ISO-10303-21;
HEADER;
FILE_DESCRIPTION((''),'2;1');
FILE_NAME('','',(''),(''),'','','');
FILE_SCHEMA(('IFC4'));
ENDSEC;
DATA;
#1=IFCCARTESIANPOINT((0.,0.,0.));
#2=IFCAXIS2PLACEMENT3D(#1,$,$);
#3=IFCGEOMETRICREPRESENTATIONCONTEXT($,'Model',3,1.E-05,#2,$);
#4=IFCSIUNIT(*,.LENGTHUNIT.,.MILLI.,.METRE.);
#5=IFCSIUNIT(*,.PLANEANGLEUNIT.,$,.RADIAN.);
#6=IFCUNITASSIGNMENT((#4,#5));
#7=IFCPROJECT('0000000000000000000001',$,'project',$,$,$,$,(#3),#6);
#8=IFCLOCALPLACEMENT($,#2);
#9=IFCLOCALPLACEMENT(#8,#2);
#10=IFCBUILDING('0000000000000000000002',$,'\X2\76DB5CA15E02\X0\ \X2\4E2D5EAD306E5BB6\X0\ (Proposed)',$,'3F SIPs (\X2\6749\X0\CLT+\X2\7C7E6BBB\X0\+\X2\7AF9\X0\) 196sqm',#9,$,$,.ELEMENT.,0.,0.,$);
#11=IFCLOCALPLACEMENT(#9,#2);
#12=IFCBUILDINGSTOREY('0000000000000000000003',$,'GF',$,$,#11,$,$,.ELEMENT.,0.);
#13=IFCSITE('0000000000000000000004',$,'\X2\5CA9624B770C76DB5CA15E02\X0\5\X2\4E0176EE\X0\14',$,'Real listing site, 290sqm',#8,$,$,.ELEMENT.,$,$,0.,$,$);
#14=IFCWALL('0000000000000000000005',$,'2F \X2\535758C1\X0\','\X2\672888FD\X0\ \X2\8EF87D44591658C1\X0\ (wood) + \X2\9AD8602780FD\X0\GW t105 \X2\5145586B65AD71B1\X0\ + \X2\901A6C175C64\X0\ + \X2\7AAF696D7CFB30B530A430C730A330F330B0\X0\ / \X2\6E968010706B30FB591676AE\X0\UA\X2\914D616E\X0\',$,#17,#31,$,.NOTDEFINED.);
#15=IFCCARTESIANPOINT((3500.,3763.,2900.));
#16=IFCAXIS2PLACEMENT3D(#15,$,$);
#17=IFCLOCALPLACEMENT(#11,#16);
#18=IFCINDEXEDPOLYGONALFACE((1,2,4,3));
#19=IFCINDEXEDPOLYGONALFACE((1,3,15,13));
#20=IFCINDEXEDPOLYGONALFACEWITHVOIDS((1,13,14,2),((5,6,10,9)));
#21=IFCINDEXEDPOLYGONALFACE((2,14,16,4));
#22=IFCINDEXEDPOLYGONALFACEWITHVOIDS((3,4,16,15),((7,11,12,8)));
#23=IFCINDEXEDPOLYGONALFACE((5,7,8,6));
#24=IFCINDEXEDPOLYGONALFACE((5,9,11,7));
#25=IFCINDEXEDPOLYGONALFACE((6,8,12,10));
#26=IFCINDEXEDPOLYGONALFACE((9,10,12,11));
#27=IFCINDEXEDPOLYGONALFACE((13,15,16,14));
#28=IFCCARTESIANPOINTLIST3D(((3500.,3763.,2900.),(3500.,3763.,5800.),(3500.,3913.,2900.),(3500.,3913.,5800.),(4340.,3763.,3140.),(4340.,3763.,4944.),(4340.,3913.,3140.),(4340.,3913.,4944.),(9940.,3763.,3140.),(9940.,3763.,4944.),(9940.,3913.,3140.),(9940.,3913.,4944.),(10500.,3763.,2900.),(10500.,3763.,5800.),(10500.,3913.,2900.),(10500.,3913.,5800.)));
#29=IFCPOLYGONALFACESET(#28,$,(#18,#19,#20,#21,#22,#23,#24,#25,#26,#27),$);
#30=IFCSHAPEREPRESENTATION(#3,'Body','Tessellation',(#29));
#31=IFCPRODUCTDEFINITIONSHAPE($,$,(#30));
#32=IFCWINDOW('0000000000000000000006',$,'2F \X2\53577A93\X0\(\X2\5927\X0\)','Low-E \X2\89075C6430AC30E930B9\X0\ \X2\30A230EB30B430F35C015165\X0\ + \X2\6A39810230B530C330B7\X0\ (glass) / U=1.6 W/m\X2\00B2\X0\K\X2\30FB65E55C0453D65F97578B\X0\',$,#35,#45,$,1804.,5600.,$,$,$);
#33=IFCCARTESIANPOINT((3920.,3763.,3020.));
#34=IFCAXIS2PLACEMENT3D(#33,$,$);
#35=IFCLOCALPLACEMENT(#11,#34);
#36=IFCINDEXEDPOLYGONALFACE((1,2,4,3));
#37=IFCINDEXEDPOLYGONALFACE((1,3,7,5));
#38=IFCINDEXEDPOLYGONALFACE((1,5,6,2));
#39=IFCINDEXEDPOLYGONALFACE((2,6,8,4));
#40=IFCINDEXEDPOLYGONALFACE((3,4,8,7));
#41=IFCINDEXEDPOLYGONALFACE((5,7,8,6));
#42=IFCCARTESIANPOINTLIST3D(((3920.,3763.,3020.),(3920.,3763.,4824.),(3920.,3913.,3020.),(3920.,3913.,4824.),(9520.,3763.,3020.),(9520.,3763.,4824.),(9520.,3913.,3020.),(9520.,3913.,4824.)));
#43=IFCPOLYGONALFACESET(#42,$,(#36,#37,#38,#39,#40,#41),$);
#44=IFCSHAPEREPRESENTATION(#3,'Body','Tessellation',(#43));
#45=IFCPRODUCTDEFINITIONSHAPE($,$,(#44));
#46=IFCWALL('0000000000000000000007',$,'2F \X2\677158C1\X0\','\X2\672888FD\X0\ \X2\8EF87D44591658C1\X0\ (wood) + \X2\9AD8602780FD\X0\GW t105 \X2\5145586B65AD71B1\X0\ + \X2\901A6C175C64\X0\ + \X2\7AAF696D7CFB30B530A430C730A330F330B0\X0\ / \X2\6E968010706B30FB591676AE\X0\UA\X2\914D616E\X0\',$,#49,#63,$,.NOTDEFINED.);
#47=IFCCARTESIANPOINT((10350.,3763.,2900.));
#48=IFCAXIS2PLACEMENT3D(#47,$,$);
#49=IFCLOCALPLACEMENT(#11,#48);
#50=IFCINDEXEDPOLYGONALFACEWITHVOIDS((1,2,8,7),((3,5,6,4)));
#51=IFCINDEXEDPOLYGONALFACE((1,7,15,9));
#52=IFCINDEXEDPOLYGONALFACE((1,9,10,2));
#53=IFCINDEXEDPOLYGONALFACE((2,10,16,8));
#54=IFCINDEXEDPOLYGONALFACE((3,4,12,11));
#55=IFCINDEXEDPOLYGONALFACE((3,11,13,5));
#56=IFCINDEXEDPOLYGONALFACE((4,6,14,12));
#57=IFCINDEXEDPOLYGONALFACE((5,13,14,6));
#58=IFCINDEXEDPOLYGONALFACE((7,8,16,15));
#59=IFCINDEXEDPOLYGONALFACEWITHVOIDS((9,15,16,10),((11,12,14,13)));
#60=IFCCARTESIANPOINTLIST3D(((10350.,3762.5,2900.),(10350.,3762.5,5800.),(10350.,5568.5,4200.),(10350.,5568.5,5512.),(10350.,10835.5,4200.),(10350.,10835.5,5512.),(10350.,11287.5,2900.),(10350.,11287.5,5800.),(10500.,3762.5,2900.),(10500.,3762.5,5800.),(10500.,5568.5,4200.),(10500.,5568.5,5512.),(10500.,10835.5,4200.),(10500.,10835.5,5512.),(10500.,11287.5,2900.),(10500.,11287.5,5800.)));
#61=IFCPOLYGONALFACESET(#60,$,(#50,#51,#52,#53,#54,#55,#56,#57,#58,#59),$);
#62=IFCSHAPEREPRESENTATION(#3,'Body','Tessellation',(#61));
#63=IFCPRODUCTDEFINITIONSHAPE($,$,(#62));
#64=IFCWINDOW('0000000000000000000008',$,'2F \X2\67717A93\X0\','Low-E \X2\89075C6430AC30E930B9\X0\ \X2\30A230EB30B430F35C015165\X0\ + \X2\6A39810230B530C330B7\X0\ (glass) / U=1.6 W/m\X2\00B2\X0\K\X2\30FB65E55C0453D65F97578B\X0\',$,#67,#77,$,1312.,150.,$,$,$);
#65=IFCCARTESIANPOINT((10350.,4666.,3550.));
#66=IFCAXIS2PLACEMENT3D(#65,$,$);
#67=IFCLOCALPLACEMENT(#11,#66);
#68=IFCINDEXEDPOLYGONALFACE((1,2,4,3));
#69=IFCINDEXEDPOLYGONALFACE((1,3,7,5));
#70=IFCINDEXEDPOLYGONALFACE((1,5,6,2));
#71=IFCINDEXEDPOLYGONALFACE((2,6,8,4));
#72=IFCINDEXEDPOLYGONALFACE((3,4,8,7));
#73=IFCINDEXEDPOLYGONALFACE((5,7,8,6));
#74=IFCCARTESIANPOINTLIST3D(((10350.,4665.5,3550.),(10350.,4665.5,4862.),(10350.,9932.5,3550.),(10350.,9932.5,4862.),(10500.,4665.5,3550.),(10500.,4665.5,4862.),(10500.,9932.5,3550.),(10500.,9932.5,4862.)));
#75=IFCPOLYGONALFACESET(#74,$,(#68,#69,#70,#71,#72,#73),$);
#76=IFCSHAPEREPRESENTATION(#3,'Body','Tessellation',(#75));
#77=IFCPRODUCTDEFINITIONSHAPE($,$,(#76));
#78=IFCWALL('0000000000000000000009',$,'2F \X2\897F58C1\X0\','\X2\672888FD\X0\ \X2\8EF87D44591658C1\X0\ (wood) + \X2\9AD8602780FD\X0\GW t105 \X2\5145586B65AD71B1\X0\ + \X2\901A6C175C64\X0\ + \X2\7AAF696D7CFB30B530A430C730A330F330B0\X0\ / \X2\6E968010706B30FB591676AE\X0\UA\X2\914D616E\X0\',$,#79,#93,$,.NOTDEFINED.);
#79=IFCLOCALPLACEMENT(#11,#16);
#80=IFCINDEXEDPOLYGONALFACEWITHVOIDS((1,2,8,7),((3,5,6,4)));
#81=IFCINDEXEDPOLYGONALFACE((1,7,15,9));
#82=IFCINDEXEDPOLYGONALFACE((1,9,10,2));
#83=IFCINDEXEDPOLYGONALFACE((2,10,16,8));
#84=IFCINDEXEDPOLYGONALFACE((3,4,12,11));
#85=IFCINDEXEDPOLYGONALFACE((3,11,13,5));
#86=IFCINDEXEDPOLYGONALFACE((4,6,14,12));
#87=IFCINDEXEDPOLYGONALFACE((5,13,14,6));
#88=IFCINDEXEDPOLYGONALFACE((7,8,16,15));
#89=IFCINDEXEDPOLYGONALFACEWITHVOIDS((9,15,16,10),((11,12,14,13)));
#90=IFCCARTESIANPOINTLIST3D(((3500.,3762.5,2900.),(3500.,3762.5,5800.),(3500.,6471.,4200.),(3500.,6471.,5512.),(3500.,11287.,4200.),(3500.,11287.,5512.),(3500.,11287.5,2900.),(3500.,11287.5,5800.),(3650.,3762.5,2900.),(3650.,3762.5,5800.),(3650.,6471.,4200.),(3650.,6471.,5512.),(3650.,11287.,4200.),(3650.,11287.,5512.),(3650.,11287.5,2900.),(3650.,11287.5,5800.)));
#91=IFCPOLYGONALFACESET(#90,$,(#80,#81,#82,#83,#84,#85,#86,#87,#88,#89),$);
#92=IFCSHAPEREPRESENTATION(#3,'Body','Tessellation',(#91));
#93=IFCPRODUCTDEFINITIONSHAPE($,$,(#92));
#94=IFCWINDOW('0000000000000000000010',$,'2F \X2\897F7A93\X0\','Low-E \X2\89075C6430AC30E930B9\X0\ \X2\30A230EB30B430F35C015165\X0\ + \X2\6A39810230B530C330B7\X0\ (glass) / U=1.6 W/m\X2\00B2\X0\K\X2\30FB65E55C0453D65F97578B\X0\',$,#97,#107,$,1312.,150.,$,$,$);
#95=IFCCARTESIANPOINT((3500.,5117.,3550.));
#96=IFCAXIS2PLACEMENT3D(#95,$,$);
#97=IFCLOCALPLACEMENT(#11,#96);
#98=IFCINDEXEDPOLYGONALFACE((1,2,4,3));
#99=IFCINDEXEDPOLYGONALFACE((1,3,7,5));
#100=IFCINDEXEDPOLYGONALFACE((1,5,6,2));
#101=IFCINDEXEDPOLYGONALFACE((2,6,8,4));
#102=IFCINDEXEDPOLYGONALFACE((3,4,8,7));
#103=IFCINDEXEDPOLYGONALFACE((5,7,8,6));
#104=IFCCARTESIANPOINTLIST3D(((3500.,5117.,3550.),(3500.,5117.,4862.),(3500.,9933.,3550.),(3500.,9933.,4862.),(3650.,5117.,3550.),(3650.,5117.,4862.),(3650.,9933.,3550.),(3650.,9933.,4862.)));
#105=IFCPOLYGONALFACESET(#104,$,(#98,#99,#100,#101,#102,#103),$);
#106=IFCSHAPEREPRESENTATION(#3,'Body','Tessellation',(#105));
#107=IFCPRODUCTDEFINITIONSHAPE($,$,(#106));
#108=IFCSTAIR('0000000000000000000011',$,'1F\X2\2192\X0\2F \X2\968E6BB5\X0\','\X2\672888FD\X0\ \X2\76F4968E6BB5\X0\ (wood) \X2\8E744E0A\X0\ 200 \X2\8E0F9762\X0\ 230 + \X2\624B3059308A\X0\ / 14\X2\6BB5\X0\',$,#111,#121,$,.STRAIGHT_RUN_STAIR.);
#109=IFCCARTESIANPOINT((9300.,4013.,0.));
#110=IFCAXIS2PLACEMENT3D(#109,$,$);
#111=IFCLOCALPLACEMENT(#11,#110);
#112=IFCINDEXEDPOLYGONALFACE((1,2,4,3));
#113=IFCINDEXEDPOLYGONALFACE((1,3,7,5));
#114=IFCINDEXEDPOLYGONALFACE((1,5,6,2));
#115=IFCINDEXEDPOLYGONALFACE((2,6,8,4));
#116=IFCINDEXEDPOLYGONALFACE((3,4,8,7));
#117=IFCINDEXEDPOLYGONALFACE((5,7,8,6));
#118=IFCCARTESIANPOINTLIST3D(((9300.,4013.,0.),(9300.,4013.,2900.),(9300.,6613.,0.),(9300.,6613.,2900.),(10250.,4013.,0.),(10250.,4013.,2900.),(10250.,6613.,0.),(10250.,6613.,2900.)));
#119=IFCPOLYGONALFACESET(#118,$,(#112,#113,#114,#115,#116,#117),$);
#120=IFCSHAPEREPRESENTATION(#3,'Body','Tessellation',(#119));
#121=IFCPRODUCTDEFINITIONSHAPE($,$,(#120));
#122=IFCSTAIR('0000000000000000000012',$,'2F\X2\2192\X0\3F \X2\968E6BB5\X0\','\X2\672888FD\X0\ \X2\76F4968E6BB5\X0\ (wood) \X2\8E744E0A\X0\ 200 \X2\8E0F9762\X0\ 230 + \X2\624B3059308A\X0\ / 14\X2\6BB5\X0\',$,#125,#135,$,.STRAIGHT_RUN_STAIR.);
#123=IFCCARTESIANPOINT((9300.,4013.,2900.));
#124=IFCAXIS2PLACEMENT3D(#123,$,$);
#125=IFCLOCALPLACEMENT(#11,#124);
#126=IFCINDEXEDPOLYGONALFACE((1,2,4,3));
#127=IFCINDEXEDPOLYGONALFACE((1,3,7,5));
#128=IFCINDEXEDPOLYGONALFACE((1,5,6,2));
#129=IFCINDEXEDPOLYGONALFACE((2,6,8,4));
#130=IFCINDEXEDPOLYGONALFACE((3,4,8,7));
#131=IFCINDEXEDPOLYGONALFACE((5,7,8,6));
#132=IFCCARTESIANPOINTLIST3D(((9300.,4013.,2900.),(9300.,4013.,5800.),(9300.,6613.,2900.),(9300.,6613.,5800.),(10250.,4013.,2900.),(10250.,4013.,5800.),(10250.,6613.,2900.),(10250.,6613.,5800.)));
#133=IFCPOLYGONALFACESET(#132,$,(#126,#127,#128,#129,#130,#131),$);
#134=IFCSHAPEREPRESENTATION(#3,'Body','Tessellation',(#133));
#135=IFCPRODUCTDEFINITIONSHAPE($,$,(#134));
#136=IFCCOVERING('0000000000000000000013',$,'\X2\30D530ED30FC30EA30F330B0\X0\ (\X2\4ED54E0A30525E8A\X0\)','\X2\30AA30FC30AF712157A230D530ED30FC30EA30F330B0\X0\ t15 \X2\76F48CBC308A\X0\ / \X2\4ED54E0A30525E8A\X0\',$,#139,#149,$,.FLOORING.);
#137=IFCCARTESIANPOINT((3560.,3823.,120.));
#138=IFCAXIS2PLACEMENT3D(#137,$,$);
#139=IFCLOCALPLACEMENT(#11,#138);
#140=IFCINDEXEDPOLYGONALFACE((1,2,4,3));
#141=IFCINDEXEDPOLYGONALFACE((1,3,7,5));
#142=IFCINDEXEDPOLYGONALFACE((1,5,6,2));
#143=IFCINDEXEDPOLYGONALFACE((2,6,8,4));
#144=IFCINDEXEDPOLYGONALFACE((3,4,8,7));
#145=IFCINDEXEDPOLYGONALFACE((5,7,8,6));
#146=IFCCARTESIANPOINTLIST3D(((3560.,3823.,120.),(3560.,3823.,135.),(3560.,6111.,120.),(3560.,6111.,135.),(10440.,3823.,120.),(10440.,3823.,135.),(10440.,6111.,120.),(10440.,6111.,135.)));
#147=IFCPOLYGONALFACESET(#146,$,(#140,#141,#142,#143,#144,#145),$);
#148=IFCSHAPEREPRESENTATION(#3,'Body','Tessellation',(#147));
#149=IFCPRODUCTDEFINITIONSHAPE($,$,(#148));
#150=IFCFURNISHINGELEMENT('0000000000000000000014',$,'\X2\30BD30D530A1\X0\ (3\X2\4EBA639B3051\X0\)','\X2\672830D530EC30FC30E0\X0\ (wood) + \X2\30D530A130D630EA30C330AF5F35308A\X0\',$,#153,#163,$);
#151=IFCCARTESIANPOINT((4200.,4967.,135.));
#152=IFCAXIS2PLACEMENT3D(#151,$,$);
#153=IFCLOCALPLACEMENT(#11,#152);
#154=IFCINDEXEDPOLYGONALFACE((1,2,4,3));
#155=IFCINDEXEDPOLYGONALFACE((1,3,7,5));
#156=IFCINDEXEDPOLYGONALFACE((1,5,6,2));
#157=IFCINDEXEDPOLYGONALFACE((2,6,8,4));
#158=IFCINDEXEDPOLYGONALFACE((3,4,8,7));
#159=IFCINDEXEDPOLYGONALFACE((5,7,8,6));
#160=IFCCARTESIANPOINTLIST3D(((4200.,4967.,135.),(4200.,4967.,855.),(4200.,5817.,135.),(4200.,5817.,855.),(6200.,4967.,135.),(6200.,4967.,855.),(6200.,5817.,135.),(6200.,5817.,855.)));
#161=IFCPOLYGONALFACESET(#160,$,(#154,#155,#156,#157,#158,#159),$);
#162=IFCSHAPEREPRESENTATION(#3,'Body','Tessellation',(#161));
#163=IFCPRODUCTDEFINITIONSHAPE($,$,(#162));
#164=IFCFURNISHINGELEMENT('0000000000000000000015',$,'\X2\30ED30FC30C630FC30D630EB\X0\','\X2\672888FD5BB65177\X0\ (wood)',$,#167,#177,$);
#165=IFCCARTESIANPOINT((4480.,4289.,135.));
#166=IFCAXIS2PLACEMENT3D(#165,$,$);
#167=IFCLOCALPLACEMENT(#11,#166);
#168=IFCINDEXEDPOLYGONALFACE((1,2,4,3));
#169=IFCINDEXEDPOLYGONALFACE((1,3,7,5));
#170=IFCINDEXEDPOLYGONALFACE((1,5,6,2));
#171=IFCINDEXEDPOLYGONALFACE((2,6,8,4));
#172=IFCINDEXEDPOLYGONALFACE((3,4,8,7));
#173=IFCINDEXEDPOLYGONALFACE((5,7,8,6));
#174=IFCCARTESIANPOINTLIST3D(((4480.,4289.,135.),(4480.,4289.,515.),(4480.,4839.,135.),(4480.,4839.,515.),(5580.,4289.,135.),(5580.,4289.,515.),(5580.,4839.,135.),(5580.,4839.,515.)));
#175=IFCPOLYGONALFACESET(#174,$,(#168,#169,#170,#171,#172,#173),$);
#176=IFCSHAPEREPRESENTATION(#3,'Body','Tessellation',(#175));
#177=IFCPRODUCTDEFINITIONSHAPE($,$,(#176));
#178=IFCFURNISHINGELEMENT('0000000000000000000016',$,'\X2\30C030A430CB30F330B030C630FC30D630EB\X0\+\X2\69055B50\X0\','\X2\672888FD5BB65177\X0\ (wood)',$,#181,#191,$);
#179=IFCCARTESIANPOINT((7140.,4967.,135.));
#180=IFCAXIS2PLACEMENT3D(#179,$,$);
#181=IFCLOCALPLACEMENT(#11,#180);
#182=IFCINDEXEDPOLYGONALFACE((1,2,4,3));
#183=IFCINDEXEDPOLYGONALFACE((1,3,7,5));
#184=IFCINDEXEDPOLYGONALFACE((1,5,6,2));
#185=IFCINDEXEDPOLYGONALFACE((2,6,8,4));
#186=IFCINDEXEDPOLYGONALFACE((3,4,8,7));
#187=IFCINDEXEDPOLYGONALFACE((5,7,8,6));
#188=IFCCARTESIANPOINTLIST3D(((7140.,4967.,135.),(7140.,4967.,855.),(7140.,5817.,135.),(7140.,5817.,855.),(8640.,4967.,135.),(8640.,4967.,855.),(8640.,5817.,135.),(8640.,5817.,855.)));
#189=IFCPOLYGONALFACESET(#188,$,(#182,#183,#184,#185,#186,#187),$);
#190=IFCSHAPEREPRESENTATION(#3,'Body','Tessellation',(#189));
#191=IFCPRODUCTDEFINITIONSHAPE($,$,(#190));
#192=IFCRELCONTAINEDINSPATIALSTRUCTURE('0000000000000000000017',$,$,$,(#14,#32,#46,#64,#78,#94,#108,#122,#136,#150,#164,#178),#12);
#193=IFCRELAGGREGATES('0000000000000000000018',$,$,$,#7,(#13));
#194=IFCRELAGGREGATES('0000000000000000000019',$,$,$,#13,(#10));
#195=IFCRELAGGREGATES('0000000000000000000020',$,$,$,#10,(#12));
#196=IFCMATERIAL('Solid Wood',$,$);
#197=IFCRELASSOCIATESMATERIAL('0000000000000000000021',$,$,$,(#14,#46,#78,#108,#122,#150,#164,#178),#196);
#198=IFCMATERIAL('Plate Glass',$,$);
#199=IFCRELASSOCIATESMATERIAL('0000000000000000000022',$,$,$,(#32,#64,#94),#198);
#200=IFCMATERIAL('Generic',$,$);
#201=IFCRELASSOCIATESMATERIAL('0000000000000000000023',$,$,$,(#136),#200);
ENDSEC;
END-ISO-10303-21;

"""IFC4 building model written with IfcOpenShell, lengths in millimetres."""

from ifc_helpers import new_model, si_unit, frame, frame_2d, origin, place, context, project, spatial, rectangle, extrude, material, element, fill, save


model = new_model("IFC4")

# Units and contexts
model_context = context("Model", 3, precision=1e-05, world=origin())
ifc_project = project(units=[si_unit("LENGTHUNIT", "METRE", prefix="MILLI"), si_unit("PLANEANGLEUNIT", "RADIAN")], contexts=[model_context])

# Site, building, storey
site_placement = place(None, origin())
site = spatial("IfcSite", under=ifc_project, at=site_placement, Name="岩手県盛岡市5丁目14", ObjectType="Real listing site, 290sqm", CompositionType="ELEMENT", RefElevation=0.0)
building_placement = place(site_placement, origin())
building = spatial("IfcBuilding", under=site, at=building_placement, Name="盛岡市 中庭の家 (Proposed)", ObjectType="3F SIPs (杉CLT+籾殻+竹) 196sqm", CompositionType="ELEMENT", ElevationOfRefHeight=0.0, ElevationOfTerrain=0.0)
storey_placement = place(building_placement, origin())
storey = spatial("IfcBuildingStorey", under=building, at=storey_placement, Name="GF", CompositionType="ELEMENT", Elevation=0.0)

# Shared definitions
ifc_material_1 = material(Name="Solid Wood")

# Shared definitions
ifc_material_2 = material(Name="Plate Glass")

# Walls, openings, windows
wall_1_placement = place(storey_placement, frame((3500.0, 3763.0, 2900.0)))
wall_1 = element("IfcWall", 1, at=wall_1_placement, inside=storey, material=ifc_material_1, Name="2F 南壁", Description="木製 軸組外壁 (wood) + 高性能GW t105 充填断熱 + 通気層 + 窯業系サイディング / 準耐火・外皮UA配慮", PredefinedType="NOTDEFINED", context=model_context, shape_type="SweptSolid", body=[
    extrude(rectangle(XDim=7000.0, YDim=150.0, at=frame_2d((3500.0, 75.0))), frame((3500.0, 3763.0, 2900.0)), (0.0, 0.0, 1.0), 2900.0),
])
opening_1_placement = place(storey_placement, frame((3920.0, 3763.0, 3020.0)))
opening_1 = element("IfcOpeningElement", 2, at=opening_1_placement, cuts=wall_1, PredefinedType="NOTDEFINED", context=model_context, shape_type="SweptSolid", body=[
    extrude(rectangle(XDim=5600.0, YDim=150.0, at=frame_2d((2800.0, 75.0))), frame((3920.0, 3763.0, 3020.0)), (0.0, 0.0, 1.0), 1804.0),
])
window_1_placement = place(storey_placement, frame((3920.0, 3763.0, 3020.0)))
window_1 = element("IfcWindow", 3, at=window_1_placement, inside=storey, material=ifc_material_2, Name="2F 南窓(大)", Description="Low-E 複層ガラス アルゴン封入 + 樹脂サッシ (glass) / U=1.6 W/m²K・日射取得型", OverallHeight=1804.0, OverallWidth=5600.0, context=model_context, shape_type="SweptSolid", body=[
    extrude(rectangle(XDim=5600.0, YDim=150.0, at=frame_2d((2800.0, 75.0))), frame((3920.0, 3763.0, 3020.0)), (0.0, 0.0, 1.0), 1804.0),
])
fill(opening_1, window_1)
wall_2_placement = place(storey_placement, frame((10350.0, 3763.0, 2900.0)))
wall_2 = element("IfcWall", 4, at=wall_2_placement, inside=storey, material=ifc_material_1, Name="2F 東壁", Description="木製 軸組外壁 (wood) + 高性能GW t105 充填断熱 + 通気層 + 窯業系サイディング / 準耐火・外皮UA配慮", PredefinedType="NOTDEFINED", context=model_context, shape_type="SweptSolid", body=[
    extrude(rectangle(XDim=150.0, YDim=7525.0, at=frame_2d((75.0, 3762.0))), frame((10350.0, 3763.0, 2900.0)), (0.0, 0.0, 1.0), 2900.0),
])
opening_2_placement = place(storey_placement, frame((10350.0, 4666.0, 3550.0)))
opening_2 = element("IfcOpeningElement", 5, at=opening_2_placement, cuts=wall_2, PredefinedType="NOTDEFINED", context=model_context, shape_type="SweptSolid", body=[
    extrude(rectangle(XDim=150.0, YDim=5267.0, at=frame_2d((75.0, 2633.0))), frame((10350.0, 4666.0, 3550.0)), (0.0, 0.0, 1.0), 1312.0),
])
window_2_placement = place(storey_placement, frame((10350.0, 4666.0, 3550.0)))
window_2 = element("IfcWindow", 6, at=window_2_placement, inside=storey, material=ifc_material_2, Name="2F 東窓", Description="Low-E 複層ガラス アルゴン封入 + 樹脂サッシ (glass) / U=1.6 W/m²K・日射取得型", OverallHeight=1312.0, OverallWidth=150.0, context=model_context, shape_type="SweptSolid", body=[
    extrude(rectangle(XDim=150.0, YDim=5267.0, at=frame_2d((75.0, 2633.0))), frame((10350.0, 4666.0, 3550.0)), (0.0, 0.0, 1.0), 1312.0),
])
fill(opening_2, window_2)
wall_3_placement = place(storey_placement, frame((3500.0, 3763.0, 2900.0)))
wall_3 = element("IfcWall", 7, at=wall_3_placement, inside=storey, material=ifc_material_1, Name="2F 西壁", Description="木製 軸組外壁 (wood) + 高性能GW t105 充填断熱 + 通気層 + 窯業系サイディング / 準耐火・外皮UA配慮", PredefinedType="NOTDEFINED", context=model_context, shape_type="SweptSolid", body=[
    extrude(rectangle(XDim=150.0, YDim=7525.0, at=frame_2d((75.0, 3762.0))), frame((3500.0, 3763.0, 2900.0)), (0.0, 0.0, 1.0), 2900.0),
])
opening_3_placement = place(storey_placement, frame((3500.0, 5117.0, 3550.0)))
opening_3 = element("IfcOpeningElement", 8, at=opening_3_placement, cuts=wall_3, PredefinedType="NOTDEFINED", context=model_context, shape_type="SweptSolid", body=[
    extrude(rectangle(XDim=150.0, YDim=4816.0, at=frame_2d((75.0, 2408.0))), frame((3500.0, 5117.0, 3550.0)), (0.0, 0.0, 1.0), 1312.0),
])
window_3_placement = place(storey_placement, frame((3500.0, 5117.0, 3550.0)))
window_3 = element("IfcWindow", 9, at=window_3_placement, inside=storey, material=ifc_material_2, Name="2F 西窓", Description="Low-E 複層ガラス アルゴン封入 + 樹脂サッシ (glass) / U=1.6 W/m²K・日射取得型", OverallHeight=1312.0, OverallWidth=150.0, context=model_context, shape_type="SweptSolid", body=[
    extrude(rectangle(XDim=150.0, YDim=4816.0, at=frame_2d((75.0, 2408.0))), frame((3500.0, 5117.0, 3550.0)), (0.0, 0.0, 1.0), 1312.0),
])
fill(opening_3, window_3)

# Stairs
stair_1_placement = place(storey_placement, frame((9300.0, 4013.0, 0.0)))
element("IfcStair", 10, at=stair_1_placement, inside=storey, material=ifc_material_1, Name="1F→2F 階段", Description="木製 直階段 (wood) 蹴上 200 踏面 230 + 手すり / 14段", PredefinedType="STRAIGHT_RUN_STAIR", context=model_context, shape_type="SweptSolid", body=[
    extrude(rectangle(XDim=950.0, YDim=2600.0, at=frame_2d((475.0, 1300.0))), frame((9300.0, 4013.0, 0.0)), (0.0, 0.0, 1.0), 2900.0),
])
stair_2_placement = place(storey_placement, frame((9300.0, 4013.0, 2900.0)))
element("IfcStair", 11, at=stair_2_placement, inside=storey, material=ifc_material_1, Name="2F→3F 階段", Description="木製 直階段 (wood) 蹴上 200 踏面 230 + 手すり / 14段", PredefinedType="STRAIGHT_RUN_STAIR", context=model_context, shape_type="SweptSolid", body=[
    extrude(rectangle(XDim=950.0, YDim=2600.0, at=frame_2d((475.0, 1300.0))), frame((9300.0, 4013.0, 2900.0)), (0.0, 0.0, 1.0), 2900.0),
])

# Covering
ifc_material_3 = material(Name="Generic")
covering_placement = place(storey_placement, frame((3560.0, 3823.0, 120.0)))
element("IfcCovering", 12, at=covering_placement, inside=storey, material=ifc_material_3, Name="フローリング (仕上げ床)", Description="オーク無垢フローリング t15 直貼り / 仕上げ床", PredefinedType="FLOORING", context=model_context, shape_type="SweptSolid", body=[
    extrude(rectangle(XDim=6880.0, YDim=2288.0, at=frame_2d((3440.0, 1144.0))), frame((3560.0, 3823.0, 120.0)), (0.0, 0.0, 1.0), 15.0),
])

# Furnishing elements
furnishing_1_placement = place(storey_placement, frame((4200.0, 4967.0, 135.0)))
element("IfcFurnishingElement", 13, at=furnishing_1_placement, inside=storey, material=ifc_material_1, Name="ソファ (3人掛け)", Description="木フレーム (wood) + ファブリック張り", context=model_context, shape_type="SweptSolid", body=[
    extrude(rectangle(XDim=2000.0, YDim=850.0, at=frame_2d((1000.0, 425.0))), frame((4200.0, 4967.0, 135.0)), (0.0, 0.0, 1.0), 720.0),
])
furnishing_2_placement = place(storey_placement, frame((4480.0, 4289.0, 135.0)))
element("IfcFurnishingElement", 14, at=furnishing_2_placement, inside=storey, material=ifc_material_1, Name="ローテーブル", Description="木製家具 (wood)", context=model_context, shape_type="SweptSolid", body=[
    extrude(rectangle(XDim=1100.0, YDim=550.0, at=frame_2d((550.0, 275.0))), frame((4480.0, 4289.0, 135.0)), (0.0, 0.0, 1.0), 380.0),
])
furnishing_3_placement = place(storey_placement, frame((7140.0, 4967.0, 135.0)))
element("IfcFurnishingElement", 15, at=furnishing_3_placement, inside=storey, material=ifc_material_1, Name="ダイニングテーブル+椅子", Description="木製家具 (wood)", context=model_context, shape_type="SweptSolid", body=[
    extrude(rectangle(XDim=1500.0, YDim=850.0, at=frame_2d((750.0, 425.0))), frame((7140.0, 4967.0, 135.0)), (0.0, 0.0, 1.0), 720.0),
])

save(model, "model.ifc")
